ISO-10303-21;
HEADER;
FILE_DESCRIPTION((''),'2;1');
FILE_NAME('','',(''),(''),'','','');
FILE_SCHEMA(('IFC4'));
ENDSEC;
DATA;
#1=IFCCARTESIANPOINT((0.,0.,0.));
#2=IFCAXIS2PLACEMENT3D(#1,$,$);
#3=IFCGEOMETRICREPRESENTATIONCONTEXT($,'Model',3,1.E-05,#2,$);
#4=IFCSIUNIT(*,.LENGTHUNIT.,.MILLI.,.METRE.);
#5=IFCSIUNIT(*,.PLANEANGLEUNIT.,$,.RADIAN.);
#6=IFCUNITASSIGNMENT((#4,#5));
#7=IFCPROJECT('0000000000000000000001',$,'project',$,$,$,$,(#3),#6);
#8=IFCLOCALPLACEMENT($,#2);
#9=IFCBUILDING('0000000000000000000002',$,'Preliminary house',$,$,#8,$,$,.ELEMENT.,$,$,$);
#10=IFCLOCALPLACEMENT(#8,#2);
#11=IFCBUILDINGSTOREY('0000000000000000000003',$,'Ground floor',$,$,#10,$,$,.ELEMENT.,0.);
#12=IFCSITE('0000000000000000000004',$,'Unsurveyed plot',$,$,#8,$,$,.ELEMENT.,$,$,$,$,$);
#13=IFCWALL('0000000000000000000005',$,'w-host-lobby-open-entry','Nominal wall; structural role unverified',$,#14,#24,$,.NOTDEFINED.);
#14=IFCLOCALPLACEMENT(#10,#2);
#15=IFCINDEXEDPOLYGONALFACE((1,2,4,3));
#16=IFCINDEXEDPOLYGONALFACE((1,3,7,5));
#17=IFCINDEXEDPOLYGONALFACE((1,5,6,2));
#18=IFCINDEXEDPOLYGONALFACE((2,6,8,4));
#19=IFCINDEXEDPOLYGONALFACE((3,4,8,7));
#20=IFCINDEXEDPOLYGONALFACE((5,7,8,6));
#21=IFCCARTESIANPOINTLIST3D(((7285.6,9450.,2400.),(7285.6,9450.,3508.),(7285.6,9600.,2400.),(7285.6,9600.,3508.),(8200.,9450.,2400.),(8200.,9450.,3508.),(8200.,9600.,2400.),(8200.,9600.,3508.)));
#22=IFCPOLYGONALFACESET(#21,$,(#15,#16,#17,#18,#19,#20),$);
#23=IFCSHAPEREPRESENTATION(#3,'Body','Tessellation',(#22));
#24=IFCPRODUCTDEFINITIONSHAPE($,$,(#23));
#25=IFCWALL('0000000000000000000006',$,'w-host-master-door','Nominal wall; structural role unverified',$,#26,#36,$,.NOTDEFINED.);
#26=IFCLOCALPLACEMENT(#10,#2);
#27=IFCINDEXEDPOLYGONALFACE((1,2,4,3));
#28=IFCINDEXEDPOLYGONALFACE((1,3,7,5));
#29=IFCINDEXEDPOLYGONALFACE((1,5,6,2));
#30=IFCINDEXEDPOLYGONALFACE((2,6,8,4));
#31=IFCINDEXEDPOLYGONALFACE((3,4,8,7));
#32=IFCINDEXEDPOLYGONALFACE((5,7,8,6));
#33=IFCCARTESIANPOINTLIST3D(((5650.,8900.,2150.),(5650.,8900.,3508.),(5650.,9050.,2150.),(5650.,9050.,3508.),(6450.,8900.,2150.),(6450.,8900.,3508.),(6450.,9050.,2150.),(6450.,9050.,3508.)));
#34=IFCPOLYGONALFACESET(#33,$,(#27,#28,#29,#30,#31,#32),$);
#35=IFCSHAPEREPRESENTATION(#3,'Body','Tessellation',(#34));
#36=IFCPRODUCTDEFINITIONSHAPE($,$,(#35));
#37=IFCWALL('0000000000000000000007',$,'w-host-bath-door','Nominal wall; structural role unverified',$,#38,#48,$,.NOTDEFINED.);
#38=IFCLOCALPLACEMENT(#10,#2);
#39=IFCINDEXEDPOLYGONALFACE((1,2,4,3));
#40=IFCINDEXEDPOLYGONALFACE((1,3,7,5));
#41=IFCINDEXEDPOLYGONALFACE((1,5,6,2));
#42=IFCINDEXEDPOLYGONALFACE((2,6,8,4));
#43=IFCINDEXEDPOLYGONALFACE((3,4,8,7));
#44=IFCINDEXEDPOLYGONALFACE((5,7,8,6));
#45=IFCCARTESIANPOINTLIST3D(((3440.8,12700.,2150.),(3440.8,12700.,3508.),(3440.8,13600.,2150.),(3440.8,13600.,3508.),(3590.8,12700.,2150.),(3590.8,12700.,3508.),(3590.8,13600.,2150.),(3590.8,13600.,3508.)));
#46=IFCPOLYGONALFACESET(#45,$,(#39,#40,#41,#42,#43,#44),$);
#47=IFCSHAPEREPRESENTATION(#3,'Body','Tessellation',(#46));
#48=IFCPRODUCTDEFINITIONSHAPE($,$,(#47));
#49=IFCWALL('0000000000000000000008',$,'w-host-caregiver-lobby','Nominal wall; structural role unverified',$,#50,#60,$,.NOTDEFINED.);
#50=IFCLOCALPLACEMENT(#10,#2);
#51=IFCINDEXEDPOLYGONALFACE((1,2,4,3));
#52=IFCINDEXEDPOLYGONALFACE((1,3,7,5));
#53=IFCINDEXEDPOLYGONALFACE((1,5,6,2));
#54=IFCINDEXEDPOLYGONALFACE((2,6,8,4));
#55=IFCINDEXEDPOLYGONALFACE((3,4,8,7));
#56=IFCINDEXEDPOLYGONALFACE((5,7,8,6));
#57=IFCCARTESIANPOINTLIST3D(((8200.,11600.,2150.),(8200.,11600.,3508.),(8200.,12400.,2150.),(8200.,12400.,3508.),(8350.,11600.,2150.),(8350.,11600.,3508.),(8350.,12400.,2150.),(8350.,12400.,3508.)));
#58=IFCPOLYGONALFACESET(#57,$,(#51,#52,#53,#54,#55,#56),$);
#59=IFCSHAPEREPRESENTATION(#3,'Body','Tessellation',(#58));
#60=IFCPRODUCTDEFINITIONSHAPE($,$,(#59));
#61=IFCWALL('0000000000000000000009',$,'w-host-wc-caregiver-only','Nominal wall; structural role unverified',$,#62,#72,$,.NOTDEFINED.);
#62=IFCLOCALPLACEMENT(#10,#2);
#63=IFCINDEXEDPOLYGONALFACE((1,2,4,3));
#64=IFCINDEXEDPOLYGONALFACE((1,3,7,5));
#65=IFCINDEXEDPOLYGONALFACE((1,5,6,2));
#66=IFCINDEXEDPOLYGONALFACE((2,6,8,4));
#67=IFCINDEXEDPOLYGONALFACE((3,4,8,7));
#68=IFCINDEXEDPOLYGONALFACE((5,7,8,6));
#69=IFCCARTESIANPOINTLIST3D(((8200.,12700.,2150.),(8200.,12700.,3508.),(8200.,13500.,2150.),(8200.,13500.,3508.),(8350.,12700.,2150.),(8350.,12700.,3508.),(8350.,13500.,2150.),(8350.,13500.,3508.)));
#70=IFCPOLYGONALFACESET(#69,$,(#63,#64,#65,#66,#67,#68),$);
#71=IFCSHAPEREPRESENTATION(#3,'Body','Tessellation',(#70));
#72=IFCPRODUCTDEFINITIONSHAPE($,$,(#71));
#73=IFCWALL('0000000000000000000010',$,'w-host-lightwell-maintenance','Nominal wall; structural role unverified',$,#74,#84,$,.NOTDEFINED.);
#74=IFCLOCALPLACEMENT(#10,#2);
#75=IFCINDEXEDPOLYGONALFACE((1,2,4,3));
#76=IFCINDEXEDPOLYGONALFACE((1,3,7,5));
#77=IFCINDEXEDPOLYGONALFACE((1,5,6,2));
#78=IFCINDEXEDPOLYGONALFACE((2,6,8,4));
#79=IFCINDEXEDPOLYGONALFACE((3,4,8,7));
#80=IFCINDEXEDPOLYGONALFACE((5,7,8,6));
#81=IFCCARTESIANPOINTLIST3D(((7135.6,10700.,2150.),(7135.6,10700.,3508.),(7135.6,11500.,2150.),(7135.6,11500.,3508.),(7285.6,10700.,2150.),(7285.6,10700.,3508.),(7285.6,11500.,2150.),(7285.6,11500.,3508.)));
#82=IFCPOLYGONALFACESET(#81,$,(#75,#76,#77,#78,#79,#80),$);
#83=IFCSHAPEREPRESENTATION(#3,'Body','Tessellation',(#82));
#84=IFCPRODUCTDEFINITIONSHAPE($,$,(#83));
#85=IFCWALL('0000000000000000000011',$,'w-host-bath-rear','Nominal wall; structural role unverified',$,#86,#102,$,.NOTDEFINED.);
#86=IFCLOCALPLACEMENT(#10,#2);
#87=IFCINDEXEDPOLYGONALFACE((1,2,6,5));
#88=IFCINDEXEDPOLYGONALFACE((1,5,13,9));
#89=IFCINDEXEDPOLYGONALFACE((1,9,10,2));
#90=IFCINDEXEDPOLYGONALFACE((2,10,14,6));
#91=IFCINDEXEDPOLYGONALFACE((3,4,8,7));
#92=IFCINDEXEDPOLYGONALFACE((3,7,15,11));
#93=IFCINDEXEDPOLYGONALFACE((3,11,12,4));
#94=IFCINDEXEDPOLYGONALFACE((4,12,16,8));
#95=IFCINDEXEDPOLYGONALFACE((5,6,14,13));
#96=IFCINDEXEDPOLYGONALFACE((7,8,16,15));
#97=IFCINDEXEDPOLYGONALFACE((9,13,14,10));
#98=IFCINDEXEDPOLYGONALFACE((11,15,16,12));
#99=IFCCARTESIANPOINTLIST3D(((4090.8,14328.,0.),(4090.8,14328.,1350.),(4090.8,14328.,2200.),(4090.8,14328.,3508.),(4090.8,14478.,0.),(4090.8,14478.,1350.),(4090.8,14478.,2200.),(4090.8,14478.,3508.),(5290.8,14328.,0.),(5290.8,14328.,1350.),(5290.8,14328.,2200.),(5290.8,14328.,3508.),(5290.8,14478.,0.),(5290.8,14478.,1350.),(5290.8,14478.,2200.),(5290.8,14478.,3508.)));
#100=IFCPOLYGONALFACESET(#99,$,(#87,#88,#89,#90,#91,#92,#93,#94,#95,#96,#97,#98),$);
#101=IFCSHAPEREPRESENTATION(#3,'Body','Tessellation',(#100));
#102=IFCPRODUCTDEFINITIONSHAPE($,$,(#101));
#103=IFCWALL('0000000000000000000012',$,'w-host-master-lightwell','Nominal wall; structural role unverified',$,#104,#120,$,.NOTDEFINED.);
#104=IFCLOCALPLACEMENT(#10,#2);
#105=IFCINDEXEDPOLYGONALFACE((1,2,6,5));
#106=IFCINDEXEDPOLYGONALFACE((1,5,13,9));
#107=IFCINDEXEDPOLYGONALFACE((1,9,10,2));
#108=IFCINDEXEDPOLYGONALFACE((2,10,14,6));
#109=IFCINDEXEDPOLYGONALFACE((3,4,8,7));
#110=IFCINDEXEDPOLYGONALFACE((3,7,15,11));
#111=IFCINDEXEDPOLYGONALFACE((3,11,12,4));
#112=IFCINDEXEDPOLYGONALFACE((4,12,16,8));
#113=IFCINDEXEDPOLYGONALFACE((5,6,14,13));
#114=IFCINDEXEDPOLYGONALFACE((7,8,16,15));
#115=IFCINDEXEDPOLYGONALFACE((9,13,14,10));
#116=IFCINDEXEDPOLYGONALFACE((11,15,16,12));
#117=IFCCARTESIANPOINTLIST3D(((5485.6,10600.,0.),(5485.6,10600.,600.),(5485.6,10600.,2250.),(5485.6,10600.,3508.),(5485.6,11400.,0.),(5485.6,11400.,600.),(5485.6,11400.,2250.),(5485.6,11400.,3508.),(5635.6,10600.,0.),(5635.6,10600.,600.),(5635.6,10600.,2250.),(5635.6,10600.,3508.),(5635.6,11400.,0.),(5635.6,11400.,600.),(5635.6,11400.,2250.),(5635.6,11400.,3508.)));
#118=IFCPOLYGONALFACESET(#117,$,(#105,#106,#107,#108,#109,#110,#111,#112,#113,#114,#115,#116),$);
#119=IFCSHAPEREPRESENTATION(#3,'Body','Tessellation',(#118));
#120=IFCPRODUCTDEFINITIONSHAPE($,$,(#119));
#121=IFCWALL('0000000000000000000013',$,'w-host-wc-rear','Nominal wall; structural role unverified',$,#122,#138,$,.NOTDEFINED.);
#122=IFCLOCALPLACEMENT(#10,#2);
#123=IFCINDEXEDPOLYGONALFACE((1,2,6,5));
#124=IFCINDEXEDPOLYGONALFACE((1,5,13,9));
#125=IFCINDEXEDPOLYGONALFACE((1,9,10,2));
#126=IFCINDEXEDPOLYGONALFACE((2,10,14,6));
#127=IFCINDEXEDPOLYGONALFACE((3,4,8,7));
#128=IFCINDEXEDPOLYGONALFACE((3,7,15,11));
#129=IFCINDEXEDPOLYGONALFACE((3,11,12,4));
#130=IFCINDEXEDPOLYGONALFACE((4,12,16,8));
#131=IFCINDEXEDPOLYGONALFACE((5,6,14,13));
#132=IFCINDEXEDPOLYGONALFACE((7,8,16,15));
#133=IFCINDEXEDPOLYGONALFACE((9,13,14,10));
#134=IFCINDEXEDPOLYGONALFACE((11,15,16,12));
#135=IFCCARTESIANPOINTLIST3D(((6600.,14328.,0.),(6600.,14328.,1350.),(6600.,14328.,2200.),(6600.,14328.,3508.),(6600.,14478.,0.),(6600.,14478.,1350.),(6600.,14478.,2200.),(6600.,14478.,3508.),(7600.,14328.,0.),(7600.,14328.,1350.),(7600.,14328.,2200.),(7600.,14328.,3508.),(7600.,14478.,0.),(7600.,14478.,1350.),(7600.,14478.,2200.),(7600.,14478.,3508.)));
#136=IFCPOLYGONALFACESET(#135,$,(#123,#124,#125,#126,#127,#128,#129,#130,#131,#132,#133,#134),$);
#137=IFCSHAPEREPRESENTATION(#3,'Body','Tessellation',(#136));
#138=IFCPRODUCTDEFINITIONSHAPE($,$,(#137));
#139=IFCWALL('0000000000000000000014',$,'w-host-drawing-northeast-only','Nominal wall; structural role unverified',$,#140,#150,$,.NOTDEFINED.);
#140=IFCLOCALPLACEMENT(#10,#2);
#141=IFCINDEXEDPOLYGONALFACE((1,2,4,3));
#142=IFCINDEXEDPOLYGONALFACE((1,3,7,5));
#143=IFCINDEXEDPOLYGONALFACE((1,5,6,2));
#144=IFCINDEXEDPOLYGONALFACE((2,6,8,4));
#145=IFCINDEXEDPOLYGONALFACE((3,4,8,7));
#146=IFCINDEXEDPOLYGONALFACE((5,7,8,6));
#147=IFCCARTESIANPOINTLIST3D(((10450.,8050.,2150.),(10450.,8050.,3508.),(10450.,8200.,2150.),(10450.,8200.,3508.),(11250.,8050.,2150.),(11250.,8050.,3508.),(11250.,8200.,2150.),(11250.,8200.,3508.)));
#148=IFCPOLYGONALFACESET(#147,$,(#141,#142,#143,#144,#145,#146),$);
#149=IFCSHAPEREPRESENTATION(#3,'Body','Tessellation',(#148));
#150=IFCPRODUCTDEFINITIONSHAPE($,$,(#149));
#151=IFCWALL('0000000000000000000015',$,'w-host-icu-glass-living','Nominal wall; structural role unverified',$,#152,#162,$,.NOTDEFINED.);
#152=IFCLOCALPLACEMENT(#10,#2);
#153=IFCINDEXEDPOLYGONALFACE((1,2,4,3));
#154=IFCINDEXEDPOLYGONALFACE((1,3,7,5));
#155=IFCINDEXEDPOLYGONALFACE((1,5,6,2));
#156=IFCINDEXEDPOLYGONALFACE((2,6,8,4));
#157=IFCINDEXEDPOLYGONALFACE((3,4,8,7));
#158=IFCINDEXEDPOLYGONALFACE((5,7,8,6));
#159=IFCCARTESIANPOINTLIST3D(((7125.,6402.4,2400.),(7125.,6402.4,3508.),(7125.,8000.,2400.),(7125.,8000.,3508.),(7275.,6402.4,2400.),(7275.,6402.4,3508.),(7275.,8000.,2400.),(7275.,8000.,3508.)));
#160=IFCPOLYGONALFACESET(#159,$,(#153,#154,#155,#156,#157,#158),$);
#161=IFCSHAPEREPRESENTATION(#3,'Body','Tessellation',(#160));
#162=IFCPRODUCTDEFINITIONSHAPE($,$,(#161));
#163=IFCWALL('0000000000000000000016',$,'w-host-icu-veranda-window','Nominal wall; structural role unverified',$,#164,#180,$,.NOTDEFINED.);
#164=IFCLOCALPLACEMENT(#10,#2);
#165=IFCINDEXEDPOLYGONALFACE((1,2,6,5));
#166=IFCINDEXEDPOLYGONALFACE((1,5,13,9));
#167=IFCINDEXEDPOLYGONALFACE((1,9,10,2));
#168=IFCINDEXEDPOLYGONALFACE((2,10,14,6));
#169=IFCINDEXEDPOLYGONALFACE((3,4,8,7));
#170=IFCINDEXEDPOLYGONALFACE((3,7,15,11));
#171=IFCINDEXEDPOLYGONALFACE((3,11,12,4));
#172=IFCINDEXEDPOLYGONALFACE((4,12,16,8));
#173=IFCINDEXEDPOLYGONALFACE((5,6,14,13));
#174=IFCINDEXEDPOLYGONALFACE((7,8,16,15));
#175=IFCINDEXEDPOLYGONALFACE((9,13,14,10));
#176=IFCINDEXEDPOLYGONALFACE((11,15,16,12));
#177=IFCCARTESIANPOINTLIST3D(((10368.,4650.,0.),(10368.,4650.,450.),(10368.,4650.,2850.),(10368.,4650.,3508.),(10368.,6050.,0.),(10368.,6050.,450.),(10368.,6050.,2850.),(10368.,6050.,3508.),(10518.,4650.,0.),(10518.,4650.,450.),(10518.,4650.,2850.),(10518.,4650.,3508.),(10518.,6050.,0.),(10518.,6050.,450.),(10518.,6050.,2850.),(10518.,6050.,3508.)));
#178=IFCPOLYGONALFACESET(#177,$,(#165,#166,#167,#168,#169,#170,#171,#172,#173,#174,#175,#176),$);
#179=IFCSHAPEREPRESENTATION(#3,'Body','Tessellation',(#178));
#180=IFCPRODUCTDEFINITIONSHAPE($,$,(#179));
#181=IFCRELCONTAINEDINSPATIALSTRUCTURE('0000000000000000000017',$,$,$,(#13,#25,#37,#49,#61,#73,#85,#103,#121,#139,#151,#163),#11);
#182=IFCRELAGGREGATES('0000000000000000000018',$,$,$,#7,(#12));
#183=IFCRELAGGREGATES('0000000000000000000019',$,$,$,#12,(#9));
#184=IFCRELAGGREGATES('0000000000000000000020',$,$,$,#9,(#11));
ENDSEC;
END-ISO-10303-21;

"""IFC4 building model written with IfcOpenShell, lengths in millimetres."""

from ifc_helpers import new_model, si_unit, frame, origin, place, context, project, spatial, polyline, outline, extrude, element, save


model = new_model("IFC4")

# Units and contexts
model_context = context("Model", 3, precision=1e-05, world=origin())
ifc_project = project(units=[si_unit("LENGTHUNIT", "METRE", prefix="MILLI"), si_unit("PLANEANGLEUNIT", "RADIAN")], contexts=[model_context])

# Site, building, storey
placement_1 = place(None, origin())
site = spatial("IfcSite", under=ifc_project, at=placement_1, Name="Unsurveyed plot", CompositionType="ELEMENT")
building = spatial("IfcBuilding", under=site, at=placement_1, Name="Preliminary house", CompositionType="ELEMENT")
placement_2 = place(placement_1, origin())
storey = spatial("IfcBuildingStorey", under=building, at=placement_2, Name="Ground floor", CompositionType="ELEMENT", Elevation=0.0)

# Walls, openings
wall_1 = element("IfcWall", 1, at=placement_2, inside=storey, Name="w-host-lobby-open-entry", Description="Nominal wall; structural role unverified", PredefinedType="NOTDEFINED", context=model_context, shape_type="SweptSolid", body=[
    extrude(outline(polyline([(7285.6, 9450.0), (8200.0, 9450.0), (8200.0, 9600.0), (7285.6, 9600.0), (7285.6, 9450.0)])), origin(), (0.0, 0.0, 1.0), 3508.0),
])
element("IfcOpeningElement", 2, at=placement_2, cuts=wall_1, PredefinedType="OPENING", context=model_context, shape_type="SweptSolid", body=[
    extrude(outline(polyline([(7285.6, 9075.0), (8200.0, 9075.0), (8200.0, 9975.0), (7285.6, 9975.0), (7285.6, 9075.0)])), origin(), (0.0, 0.0, 1.0), 2400.0),
])
wall_2 = element("IfcWall", 3, at=placement_2, inside=storey, Name="w-host-master-door", Description="Nominal wall; structural role unverified", PredefinedType="NOTDEFINED", context=model_context, shape_type="SweptSolid", body=[
    extrude(outline(polyline([(5650.0, 8900.0), (6450.0, 8900.0), (6450.0, 9050.0), (5650.0, 9050.0), (5650.0, 8900.0)])), origin(), (0.0, 0.0, 1.0), 3508.0),
])
element("IfcOpeningElement", 4, at=placement_2, cuts=wall_2, PredefinedType="OPENING", context=model_context, shape_type="SweptSolid", body=[
    extrude(outline(polyline([(5650.0, 8525.0), (6450.0, 8525.0), (6450.0, 9425.0), (5650.0, 9425.0), (5650.0, 8525.0)])), origin(), (0.0, 0.0, 1.0), 2150.0),
])
wall_3 = element("IfcWall", 5, at=placement_2, inside=storey, Name="w-host-bath-door", Description="Nominal wall; structural role unverified", PredefinedType="NOTDEFINED", context=model_context, shape_type="SweptSolid", body=[
    extrude(outline(polyline([(3590.8, 12700.0), (3590.8, 13600.0), (3440.8, 13600.0), (3440.8, 12700.0), (3590.8, 12700.0)])), origin(), (0.0, 0.0, 1.0), 3508.0),
])
element("IfcOpeningElement", 6, at=placement_2, cuts=wall_3, PredefinedType="OPENING", context=model_context, shape_type="SweptSolid", body=[
    extrude(outline(polyline([(3965.8, 12700.0), (3965.8, 13600.0), (3065.8, 13600.0), (3065.8, 12700.0), (3965.8, 12700.0)])), origin(), (0.0, 0.0, 1.0), 2150.0),
])
wall_4 = element("IfcWall", 7, at=placement_2, inside=storey, Name="w-host-caregiver-lobby", Description="Nominal wall; structural role unverified", PredefinedType="NOTDEFINED", context=model_context, shape_type="SweptSolid", body=[
    extrude(outline(polyline([(8350.0, 11600.0), (8350.0, 12400.0), (8200.0, 12400.0), (8200.0, 11600.0), (8350.0, 11600.0)])), origin(), (0.0, 0.0, 1.0), 3508.0),
])
element("IfcOpeningElement", 8, at=placement_2, cuts=wall_4, PredefinedType="OPENING", context=model_context, shape_type="SweptSolid", body=[
    extrude(outline(polyline([(8725.0, 11600.0), (8725.0, 12400.0), (7825.0, 12400.0), (7825.0, 11600.0), (8725.0, 11600.0)])), origin(), (0.0, 0.0, 1.0), 2150.0),
])
wall_5 = element("IfcWall", 9, at=placement_2, inside=storey, Name="w-host-wc-caregiver-only", Description="Nominal wall; structural role unverified", PredefinedType="NOTDEFINED", context=model_context, shape_type="SweptSolid", body=[
    extrude(outline(polyline([(8350.0, 12700.0), (8350.0, 13500.0), (8200.0, 13500.0), (8200.0, 12700.0), (8350.0, 12700.0)])), origin(), (0.0, 0.0, 1.0), 3508.0),
])
element("IfcOpeningElement", 10, at=placement_2, cuts=wall_5, PredefinedType="OPENING", context=model_context, shape_type="SweptSolid", body=[
    extrude(outline(polyline([(8725.0, 12700.0), (8725.0, 13500.0), (7825.0, 13500.0), (7825.0, 12700.0), (8725.0, 12700.0)])), origin(), (0.0, 0.0, 1.0), 2150.0),
])
wall_6 = element("IfcWall", 11, at=placement_2, inside=storey, Name="w-host-lightwell-maintenance", Description="Nominal wall; structural role unverified", PredefinedType="NOTDEFINED", context=model_context, shape_type="SweptSolid", body=[
    extrude(outline(polyline([(7285.6, 10700.0), (7285.6, 11500.0), (7135.6, 11500.0), (7135.6, 10700.0), (7285.6, 10700.0)])), origin(), (0.0, 0.0, 1.0), 3508.0),
])
element("IfcOpeningElement", 12, at=placement_2, cuts=wall_6, PredefinedType="OPENING", context=model_context, shape_type="SweptSolid", body=[
    extrude(outline(polyline([(7660.6, 10700.0), (7660.6, 11500.0), (6760.6, 11500.0), (6760.6, 10700.0), (7660.6, 10700.0)])), origin(), (0.0, 0.0, 1.0), 2150.0),
])
wall_7 = element("IfcWall", 13, at=placement_2, inside=storey, Name="w-host-bath-rear", Description="Nominal wall; structural role unverified", PredefinedType="NOTDEFINED", context=model_context, shape_type="SweptSolid", body=[
    extrude(outline(polyline([(4090.8, 14328.0), (5290.8, 14328.0), (5290.8, 14478.0), (4090.8, 14478.0), (4090.8, 14328.0)])), origin(), (0.0, 0.0, 1.0), 3508.0),
])
element("IfcOpeningElement", 14, at=placement_2, cuts=wall_7, PredefinedType="OPENING", context=model_context, shape_type="SweptSolid", body=[
    extrude(outline(polyline([(4090.8, 13953.0), (5290.8, 13953.0), (5290.8, 14853.0), (4090.8, 14853.0), (4090.8, 13953.0)])), frame((0.0, 0.0, 1350.0)), (0.0, 0.0, 1.0), 850.0),
])
wall_8 = element("IfcWall", 15, at=placement_2, inside=storey, Name="w-host-master-lightwell", Description="Nominal wall; structural role unverified", PredefinedType="NOTDEFINED", context=model_context, shape_type="SweptSolid", body=[
    extrude(outline(polyline([(5635.6, 10600.0), (5635.6, 11400.0), (5485.6, 11400.0), (5485.6, 10600.0), (5635.6, 10600.0)])), origin(), (0.0, 0.0, 1.0), 3508.0),
])
element("IfcOpeningElement", 16, at=placement_2, cuts=wall_8, PredefinedType="OPENING", context=model_context, shape_type="SweptSolid", body=[
    extrude(outline(polyline([(6010.6, 10600.0), (6010.6, 11400.0), (5110.6, 11400.0), (5110.6, 10600.0), (6010.6, 10600.0)])), frame((0.0, 0.0, 600.0)), (0.0, 0.0, 1.0), 1650.0),
])
wall_9 = element("IfcWall", 17, at=placement_2, inside=storey, Name="w-host-wc-rear", Description="Nominal wall; structural role unverified", PredefinedType="NOTDEFINED", context=model_context, shape_type="SweptSolid", body=[
    extrude(outline(polyline([(6600.0, 14328.0), (7600.0, 14328.0), (7600.0, 14478.0), (6600.0, 14478.0), (6600.0, 14328.0)])), origin(), (0.0, 0.0, 1.0), 3508.0),
])
element("IfcOpeningElement", 18, at=placement_2, cuts=wall_9, PredefinedType="OPENING", context=model_context, shape_type="SweptSolid", body=[
    extrude(outline(polyline([(6600.0, 13953.0), (7600.0, 13953.0), (7600.0, 14853.0), (6600.0, 14853.0), (6600.0, 13953.0)])), frame((0.0, 0.0, 1350.0)), (0.0, 0.0, 1.0), 850.0),
])
wall_10 = element("IfcWall", 19, at=placement_2, inside=storey, Name="w-host-drawing-northeast-only", Description="Nominal wall; structural role unverified", PredefinedType="NOTDEFINED", context=model_context, shape_type="SweptSolid", body=[
    extrude(outline(polyline([(10450.0, 8050.0), (11250.0, 8050.0), (11250.0, 8200.0), (10450.0, 8200.0), (10450.0, 8050.0)])), origin(), (0.0, 0.0, 1.0), 3508.0),
])
element("IfcOpeningElement", 20, at=placement_2, cuts=wall_10, PredefinedType="OPENING", context=model_context, shape_type="SweptSolid", body=[
    extrude(outline(polyline([(10450.0, 7675.0), (11250.0, 7675.0), (11250.0, 8575.0), (10450.0, 8575.0), (10450.0, 7675.0)])), origin(), (0.0, 0.0, 1.0), 2150.0),
])
wall_11 = element("IfcWall", 21, at=placement_2, inside=storey, Name="w-host-icu-glass-living", Description="Nominal wall; structural role unverified", PredefinedType="NOTDEFINED", context=model_context, shape_type="SweptSolid", body=[
    extrude(outline(polyline([(7275.0, 6402.4), (7275.0, 8000.0), (7125.0, 8000.0), (7125.0, 6402.4), (7275.0, 6402.4)])), origin(), (0.0, 0.0, 1.0), 3508.0),
])
element("IfcOpeningElement", 22, at=placement_2, cuts=wall_11, PredefinedType="OPENING", context=model_context, shape_type="SweptSolid", body=[
    extrude(outline(polyline([(7650.0, 6402.4), (7650.0, 8000.0), (6750.0, 8000.0), (6750.0, 6402.4), (7650.0, 6402.4)])), origin(), (0.0, 0.0, 1.0), 2400.0),
])
wall_12 = element("IfcWall", 23, at=placement_2, inside=storey, Name="w-host-icu-veranda-window", Description="Nominal wall; structural role unverified", PredefinedType="NOTDEFINED", context=model_context, shape_type="SweptSolid", body=[
    extrude(outline(polyline([(10518.0, 4650.0), (10518.0, 6050.0), (10368.0, 6050.0), (10368.0, 4650.0), (10518.0, 4650.0)])), origin(), (0.0, 0.0, 1.0), 3508.0),
])
element("IfcOpeningElement", 24, at=placement_2, cuts=wall_12, PredefinedType="OPENING", context=model_context, shape_type="SweptSolid", body=[
    extrude(outline(polyline([(10893.0, 4650.0), (10893.0, 6050.0), (9993.0, 6050.0), (9993.0, 4650.0), (10893.0, 4650.0)])), frame((0.0, 0.0, 450.0)), (0.0, 0.0, 1.0), 2400.0),
])

save(model, "model.ifc")
